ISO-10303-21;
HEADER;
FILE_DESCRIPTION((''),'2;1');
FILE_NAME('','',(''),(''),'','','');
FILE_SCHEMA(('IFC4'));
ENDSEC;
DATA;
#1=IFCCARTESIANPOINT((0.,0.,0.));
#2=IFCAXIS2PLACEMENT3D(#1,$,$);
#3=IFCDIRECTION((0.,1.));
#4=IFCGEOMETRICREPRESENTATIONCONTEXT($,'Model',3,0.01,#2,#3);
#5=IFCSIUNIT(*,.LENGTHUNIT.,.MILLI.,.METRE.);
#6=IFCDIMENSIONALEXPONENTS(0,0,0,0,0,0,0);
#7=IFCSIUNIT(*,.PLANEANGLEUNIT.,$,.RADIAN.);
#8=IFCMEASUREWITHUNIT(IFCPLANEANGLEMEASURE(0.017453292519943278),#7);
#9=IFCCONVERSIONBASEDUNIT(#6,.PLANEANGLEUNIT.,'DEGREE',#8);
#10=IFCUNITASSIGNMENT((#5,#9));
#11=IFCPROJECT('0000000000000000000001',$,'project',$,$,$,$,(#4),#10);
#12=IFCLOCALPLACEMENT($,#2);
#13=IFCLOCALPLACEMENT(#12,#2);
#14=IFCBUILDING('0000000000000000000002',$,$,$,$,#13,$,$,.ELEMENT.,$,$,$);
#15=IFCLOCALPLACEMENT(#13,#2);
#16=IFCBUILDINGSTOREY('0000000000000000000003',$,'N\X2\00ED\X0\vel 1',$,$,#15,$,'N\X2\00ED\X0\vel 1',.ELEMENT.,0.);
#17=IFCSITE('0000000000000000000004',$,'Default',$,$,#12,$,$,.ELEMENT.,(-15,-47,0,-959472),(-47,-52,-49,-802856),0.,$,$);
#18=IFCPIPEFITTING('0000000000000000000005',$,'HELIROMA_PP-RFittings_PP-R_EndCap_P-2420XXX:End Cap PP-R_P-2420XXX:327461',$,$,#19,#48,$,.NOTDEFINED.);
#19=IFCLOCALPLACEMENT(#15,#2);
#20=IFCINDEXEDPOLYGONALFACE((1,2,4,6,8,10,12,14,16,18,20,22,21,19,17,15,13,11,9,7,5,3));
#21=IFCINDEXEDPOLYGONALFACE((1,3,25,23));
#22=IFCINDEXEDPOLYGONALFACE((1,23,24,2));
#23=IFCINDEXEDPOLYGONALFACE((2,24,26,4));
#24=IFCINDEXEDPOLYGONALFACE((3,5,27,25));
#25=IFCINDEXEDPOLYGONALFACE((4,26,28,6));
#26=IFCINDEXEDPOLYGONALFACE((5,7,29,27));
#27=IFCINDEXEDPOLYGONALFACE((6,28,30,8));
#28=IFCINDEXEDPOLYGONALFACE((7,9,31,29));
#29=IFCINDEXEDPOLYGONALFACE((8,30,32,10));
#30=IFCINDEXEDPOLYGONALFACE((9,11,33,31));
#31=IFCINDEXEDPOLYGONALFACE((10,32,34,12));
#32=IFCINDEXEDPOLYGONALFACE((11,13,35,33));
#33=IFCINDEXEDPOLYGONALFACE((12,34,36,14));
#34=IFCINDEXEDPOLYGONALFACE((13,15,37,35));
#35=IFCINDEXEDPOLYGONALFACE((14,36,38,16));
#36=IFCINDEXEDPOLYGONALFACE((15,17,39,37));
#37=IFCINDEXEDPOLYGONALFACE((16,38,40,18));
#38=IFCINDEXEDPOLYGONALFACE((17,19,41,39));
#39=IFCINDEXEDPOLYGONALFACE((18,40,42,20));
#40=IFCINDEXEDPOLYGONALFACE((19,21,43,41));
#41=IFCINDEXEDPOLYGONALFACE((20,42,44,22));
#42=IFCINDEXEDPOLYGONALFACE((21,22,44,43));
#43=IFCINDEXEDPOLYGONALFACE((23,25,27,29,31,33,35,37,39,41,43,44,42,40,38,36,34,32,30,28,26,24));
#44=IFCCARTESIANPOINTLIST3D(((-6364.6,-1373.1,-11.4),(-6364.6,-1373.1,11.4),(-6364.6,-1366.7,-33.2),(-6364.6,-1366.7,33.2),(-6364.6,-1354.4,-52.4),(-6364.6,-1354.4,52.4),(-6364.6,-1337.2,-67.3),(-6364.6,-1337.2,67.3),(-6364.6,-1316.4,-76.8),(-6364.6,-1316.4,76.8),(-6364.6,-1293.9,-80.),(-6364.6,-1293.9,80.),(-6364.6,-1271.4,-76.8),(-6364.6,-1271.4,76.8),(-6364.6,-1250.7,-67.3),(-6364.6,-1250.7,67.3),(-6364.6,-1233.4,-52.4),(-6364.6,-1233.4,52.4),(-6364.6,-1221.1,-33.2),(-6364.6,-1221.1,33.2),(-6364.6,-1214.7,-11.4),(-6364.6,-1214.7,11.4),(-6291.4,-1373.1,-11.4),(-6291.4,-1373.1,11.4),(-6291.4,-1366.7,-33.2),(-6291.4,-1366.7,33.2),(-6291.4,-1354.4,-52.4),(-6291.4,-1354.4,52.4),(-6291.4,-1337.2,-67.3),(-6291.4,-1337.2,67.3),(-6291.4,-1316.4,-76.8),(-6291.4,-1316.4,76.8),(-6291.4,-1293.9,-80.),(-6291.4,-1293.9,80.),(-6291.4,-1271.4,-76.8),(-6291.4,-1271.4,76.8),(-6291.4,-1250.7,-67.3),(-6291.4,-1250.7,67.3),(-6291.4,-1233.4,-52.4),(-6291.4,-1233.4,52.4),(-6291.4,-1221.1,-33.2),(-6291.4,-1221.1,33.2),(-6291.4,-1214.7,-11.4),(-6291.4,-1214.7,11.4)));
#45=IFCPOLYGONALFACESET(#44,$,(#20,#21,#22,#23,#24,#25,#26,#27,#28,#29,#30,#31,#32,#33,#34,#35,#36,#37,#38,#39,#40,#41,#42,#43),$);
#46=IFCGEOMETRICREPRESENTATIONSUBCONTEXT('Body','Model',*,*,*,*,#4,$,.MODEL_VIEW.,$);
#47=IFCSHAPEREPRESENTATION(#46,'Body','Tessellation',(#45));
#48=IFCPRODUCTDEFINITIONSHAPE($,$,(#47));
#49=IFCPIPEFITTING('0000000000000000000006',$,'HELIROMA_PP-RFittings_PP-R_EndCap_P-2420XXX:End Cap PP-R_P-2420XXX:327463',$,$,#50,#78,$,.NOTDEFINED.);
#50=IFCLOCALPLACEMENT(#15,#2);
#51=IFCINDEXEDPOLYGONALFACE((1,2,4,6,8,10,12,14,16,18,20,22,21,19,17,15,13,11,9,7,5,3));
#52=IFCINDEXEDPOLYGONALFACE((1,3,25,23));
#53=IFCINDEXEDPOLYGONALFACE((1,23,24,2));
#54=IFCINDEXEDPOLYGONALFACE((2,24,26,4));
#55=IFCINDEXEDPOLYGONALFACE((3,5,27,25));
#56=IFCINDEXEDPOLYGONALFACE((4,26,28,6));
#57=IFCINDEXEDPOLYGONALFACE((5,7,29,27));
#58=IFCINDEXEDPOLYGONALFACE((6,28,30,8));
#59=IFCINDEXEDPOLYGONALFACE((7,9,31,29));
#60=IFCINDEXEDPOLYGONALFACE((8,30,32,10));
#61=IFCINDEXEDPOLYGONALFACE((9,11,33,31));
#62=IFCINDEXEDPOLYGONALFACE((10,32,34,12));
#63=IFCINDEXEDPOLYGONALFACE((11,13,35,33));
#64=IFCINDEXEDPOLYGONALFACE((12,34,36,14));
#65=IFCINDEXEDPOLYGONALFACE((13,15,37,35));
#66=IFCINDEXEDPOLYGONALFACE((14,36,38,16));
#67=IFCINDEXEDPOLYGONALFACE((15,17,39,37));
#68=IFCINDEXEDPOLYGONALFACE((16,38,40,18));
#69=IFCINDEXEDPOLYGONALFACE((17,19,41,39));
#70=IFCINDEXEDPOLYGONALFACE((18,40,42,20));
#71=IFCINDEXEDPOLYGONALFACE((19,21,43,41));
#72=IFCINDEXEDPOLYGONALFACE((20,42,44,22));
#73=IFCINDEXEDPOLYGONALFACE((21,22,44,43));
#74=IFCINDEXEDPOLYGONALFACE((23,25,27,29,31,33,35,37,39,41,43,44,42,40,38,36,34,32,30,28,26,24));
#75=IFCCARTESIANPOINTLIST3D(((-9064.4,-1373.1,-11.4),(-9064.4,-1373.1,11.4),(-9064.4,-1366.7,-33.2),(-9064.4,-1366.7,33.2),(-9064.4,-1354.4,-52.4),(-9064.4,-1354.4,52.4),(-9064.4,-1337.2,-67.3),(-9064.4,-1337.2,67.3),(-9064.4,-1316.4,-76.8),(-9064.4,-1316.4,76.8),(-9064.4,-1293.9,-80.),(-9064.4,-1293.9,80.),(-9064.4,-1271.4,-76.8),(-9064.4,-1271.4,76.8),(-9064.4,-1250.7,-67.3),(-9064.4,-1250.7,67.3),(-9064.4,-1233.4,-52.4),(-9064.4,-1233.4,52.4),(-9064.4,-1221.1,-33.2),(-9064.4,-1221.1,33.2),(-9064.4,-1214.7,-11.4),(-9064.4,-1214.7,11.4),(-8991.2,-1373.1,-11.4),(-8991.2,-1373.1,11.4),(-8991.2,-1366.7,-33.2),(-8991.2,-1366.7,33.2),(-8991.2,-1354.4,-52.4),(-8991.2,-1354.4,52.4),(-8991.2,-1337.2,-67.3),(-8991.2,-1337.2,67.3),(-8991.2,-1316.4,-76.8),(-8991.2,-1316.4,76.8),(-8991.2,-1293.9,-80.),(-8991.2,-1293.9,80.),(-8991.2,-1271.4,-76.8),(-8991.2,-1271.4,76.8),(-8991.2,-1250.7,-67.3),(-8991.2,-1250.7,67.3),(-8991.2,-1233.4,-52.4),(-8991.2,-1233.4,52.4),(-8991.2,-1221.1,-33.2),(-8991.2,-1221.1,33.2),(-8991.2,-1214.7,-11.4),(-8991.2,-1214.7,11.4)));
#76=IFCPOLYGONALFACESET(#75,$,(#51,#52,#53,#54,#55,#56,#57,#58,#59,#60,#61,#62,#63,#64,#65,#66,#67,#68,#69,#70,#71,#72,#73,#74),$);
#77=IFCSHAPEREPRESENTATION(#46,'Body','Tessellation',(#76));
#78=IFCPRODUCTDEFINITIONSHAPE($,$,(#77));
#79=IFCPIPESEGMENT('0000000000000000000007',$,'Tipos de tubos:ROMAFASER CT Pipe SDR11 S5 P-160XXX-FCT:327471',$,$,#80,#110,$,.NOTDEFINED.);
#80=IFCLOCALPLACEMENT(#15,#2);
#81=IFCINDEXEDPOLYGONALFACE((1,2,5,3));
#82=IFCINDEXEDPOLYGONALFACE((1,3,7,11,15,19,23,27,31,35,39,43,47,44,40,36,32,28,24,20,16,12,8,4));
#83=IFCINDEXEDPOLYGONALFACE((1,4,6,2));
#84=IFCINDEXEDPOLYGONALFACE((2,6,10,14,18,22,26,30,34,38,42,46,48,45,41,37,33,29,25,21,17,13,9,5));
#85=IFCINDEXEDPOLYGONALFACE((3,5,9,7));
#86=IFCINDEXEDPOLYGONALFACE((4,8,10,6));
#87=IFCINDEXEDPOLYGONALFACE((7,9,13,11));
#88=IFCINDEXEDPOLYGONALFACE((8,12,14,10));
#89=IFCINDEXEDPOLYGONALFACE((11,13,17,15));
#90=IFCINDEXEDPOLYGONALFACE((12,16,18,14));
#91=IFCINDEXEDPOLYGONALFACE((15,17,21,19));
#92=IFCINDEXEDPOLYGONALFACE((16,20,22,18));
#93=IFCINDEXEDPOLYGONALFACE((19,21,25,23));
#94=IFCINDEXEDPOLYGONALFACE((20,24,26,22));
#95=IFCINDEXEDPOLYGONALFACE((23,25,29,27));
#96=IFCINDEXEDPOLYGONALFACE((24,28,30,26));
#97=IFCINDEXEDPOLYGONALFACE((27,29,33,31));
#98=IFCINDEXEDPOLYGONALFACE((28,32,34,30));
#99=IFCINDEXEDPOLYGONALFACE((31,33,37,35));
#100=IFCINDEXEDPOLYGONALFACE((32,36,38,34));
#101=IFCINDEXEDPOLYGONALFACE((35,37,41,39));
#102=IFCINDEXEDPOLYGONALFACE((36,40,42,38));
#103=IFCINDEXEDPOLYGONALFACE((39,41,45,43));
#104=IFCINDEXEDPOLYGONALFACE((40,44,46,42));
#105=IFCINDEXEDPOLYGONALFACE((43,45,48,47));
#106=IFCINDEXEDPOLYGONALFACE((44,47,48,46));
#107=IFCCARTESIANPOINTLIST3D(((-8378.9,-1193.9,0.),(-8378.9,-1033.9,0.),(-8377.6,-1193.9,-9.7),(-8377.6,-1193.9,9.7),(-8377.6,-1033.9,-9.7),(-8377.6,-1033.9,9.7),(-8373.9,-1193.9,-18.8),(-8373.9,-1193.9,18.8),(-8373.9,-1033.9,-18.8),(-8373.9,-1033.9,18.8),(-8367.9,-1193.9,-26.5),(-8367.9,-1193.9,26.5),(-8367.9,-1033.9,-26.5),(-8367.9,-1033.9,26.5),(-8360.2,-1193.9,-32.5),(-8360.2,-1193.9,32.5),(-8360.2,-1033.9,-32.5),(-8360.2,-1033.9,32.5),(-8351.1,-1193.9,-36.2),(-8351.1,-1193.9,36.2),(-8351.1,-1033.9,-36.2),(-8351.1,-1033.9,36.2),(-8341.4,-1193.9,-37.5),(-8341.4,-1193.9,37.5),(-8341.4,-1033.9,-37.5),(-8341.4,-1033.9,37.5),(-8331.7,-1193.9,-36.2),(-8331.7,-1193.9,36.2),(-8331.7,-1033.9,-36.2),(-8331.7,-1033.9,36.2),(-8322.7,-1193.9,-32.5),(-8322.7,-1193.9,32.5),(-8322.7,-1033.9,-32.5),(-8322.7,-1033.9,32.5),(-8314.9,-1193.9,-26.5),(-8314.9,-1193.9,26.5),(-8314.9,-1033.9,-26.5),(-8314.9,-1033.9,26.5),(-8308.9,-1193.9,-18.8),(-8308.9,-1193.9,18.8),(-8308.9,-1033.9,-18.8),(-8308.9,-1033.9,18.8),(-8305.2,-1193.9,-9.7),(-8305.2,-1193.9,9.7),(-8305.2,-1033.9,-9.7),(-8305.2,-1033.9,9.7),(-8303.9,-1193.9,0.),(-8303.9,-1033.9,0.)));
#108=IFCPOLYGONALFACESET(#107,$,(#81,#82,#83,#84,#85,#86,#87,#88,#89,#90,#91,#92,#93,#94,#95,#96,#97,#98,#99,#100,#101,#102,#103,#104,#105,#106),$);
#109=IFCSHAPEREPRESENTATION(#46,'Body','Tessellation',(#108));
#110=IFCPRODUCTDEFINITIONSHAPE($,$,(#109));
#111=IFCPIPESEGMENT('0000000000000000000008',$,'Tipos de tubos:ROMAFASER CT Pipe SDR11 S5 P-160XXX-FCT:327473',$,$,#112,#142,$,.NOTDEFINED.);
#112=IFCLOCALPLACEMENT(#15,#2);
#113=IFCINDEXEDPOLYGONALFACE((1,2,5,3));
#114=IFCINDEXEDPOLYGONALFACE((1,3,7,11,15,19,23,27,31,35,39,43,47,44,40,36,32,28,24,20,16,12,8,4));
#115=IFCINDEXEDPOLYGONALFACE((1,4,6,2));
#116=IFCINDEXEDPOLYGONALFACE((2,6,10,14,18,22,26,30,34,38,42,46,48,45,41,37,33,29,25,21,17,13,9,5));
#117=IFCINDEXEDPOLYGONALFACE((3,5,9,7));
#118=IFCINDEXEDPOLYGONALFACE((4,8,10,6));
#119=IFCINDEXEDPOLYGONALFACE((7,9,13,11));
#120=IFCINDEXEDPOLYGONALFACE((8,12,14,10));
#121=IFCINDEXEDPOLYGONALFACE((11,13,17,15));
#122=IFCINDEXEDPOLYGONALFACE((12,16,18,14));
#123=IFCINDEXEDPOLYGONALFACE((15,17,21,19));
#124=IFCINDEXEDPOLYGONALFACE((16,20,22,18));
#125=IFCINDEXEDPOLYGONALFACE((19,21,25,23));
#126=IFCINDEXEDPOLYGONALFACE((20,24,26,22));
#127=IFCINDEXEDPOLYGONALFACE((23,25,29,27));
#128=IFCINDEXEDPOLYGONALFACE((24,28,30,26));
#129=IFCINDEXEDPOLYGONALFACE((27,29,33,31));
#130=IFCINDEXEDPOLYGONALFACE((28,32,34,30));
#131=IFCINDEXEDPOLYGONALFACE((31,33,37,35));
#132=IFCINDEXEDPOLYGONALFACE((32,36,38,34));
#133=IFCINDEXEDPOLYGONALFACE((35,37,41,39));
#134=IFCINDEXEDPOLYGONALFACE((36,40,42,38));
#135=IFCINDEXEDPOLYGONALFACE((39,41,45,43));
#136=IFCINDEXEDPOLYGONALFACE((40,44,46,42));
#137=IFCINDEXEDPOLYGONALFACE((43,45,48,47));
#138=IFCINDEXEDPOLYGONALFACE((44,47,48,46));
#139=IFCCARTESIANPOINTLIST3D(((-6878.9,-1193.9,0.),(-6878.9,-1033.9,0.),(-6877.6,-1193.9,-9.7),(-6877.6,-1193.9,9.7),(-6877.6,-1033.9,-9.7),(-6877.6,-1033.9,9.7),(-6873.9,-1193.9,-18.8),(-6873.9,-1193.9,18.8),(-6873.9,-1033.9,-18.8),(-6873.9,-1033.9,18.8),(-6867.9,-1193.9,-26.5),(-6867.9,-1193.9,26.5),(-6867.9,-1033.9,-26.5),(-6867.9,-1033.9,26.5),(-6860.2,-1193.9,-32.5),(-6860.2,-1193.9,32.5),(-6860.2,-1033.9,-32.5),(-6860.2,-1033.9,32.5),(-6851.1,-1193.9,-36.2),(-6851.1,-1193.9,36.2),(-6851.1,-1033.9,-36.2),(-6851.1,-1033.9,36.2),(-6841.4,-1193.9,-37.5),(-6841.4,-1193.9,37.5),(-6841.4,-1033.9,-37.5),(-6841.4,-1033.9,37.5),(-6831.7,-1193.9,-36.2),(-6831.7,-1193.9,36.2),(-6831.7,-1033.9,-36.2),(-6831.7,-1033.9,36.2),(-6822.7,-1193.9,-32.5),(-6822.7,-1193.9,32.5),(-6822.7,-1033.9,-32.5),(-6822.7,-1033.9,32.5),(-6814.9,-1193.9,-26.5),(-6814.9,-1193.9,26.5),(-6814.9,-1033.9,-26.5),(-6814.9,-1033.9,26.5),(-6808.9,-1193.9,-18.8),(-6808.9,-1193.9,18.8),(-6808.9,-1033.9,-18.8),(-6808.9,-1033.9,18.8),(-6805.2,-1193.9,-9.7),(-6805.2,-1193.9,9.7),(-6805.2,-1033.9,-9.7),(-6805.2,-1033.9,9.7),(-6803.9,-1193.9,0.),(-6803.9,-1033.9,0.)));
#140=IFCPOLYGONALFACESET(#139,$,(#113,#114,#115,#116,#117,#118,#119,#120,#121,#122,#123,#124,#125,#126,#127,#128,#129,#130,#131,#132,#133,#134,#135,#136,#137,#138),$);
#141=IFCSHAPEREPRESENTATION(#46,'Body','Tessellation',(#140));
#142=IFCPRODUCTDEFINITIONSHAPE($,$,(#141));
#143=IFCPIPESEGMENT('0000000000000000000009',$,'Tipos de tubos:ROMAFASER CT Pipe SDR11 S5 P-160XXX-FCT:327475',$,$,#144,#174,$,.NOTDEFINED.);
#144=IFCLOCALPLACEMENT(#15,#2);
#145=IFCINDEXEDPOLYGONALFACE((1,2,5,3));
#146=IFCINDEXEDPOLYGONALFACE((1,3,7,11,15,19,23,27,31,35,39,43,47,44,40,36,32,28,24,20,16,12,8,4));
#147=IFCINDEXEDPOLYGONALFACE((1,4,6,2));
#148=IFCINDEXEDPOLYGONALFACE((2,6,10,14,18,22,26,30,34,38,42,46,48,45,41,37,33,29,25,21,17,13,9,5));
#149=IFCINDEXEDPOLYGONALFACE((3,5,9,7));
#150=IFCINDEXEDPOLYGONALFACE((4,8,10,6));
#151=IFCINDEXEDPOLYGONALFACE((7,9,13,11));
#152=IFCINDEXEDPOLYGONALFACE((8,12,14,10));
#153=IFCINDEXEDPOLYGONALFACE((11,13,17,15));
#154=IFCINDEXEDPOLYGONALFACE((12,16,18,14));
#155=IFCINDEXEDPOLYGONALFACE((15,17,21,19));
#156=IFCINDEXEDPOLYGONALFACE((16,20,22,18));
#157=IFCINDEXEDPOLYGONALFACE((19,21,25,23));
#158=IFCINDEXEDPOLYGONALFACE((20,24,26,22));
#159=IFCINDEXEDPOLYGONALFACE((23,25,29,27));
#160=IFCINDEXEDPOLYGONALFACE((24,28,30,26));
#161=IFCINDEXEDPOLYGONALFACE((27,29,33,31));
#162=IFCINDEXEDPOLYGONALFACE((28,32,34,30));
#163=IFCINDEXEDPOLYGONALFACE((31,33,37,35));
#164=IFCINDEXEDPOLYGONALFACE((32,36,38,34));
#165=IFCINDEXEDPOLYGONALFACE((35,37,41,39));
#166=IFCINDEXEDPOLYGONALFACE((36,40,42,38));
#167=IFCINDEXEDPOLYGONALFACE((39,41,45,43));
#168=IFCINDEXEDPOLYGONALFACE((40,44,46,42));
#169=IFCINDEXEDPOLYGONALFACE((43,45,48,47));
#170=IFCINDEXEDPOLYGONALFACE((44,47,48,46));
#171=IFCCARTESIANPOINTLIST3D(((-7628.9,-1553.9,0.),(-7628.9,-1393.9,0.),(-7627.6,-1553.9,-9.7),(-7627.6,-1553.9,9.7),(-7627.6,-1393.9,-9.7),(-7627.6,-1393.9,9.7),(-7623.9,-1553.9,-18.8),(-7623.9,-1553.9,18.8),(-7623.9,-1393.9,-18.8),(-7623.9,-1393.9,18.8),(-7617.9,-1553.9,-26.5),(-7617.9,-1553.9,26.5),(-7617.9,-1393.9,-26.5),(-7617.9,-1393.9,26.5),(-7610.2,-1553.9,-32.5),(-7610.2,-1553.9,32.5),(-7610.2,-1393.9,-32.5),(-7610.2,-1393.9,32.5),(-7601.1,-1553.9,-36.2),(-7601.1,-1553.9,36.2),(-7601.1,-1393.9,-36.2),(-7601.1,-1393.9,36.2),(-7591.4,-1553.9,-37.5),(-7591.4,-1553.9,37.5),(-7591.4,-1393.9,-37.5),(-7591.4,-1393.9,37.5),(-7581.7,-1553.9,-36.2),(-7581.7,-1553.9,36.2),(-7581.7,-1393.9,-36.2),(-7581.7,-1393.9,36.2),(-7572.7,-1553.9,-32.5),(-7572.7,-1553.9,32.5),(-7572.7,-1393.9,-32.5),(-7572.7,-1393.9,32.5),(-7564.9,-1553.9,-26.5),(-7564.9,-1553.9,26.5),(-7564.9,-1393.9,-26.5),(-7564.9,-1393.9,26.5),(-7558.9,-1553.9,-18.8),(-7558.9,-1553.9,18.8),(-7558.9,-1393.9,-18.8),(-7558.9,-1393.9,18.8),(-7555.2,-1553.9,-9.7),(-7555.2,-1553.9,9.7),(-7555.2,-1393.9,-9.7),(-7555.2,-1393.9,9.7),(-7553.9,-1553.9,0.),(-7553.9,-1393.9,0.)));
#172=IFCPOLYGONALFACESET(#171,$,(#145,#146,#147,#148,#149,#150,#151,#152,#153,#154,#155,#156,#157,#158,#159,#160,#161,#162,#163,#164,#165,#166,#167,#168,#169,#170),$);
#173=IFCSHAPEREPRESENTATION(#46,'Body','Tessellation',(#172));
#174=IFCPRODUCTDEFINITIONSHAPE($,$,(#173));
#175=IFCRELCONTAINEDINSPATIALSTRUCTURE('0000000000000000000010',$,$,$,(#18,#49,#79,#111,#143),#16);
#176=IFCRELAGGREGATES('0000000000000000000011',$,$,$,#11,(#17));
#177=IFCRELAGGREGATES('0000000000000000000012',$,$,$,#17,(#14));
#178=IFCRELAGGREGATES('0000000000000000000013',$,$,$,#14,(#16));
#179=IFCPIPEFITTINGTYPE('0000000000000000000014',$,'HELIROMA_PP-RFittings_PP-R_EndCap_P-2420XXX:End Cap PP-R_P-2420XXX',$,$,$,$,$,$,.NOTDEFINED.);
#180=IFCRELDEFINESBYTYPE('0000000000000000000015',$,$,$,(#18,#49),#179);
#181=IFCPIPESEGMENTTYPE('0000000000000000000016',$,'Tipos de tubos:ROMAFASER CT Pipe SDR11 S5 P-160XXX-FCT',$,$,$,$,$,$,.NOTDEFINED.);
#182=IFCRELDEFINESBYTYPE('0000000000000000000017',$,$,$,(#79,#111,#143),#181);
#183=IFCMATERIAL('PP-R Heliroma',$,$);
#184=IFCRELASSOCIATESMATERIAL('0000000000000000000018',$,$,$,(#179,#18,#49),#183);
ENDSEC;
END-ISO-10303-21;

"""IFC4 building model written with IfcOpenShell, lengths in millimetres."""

from ifc_helpers import new_model, entity, si_unit, converted_unit, direction, frame, origin, place, context, subcontext, project, spatial, arc, indexed_curve, outline, extrude, source, transform, mapped, material, type_object, type_shapes, element, save


model = new_model("IFC4")

# Units and contexts
model_context = context("Model", 3, precision=0.01, world=origin(), true_north=direction((0.0, 1.0)))
body_context = subcontext(model_context, "Body", "Model", "MODEL_VIEW")
ifc_project = project(units=[si_unit("LENGTHUNIT", "METRE", prefix="MILLI"), converted_unit("PLANEANGLEUNIT", "DEGREE", entity("IfcPlaneAngleMeasure", 0.017453292519943278), si_unit("PLANEANGLEUNIT", "RADIAN"), dimensions=[0, 0, 0, 0, 0, 0, 0])], contexts=[model_context])

# Site, building, storey
site_placement = place(None, origin())
site = spatial("IfcSite", under=ifc_project, at=site_placement, Name="Default", CompositionType="ELEMENT", RefLatitude=(-15, -47, 0, -959472), RefLongitude=(-47, -52, -49, -802856), RefElevation=0.0)
building_placement = place(site_placement, origin())
building = spatial("IfcBuilding", under=site, at=building_placement, CompositionType="ELEMENT")
storey_placement = place(building_placement, origin())
storey = spatial("IfcBuildingStorey", under=building, at=storey_placement, Name="Nível 1", LongName="Nível 1", CompositionType="ELEMENT", Elevation=0.0)

# Pipe fittings
ifc_material_1 = material(Name="PP-R Heliroma")
pipe_fitting_type_1 = type_object("IfcPipeFittingType", Name="HELIROMA_PP-RFittings_PP-R_EndCap_P-2420XXX:End Cap PP-R_P-2420XXX", PredefinedType="NOTDEFINED", material=ifc_material_1)
shared_shape_1 = source(origin(), body_context, "Body", "SweptSolid", [
    extrude(outline(indexed_curve([(-80.0, 0.0), (0.0, -80.0), (80.0, 0.0), (0.0, 80.0)], segments=[arc(1, 2, 3), arc(3, 4, 1)], self_intersect=False)), frame((0.0, 0.0, 0.0), z_axis=(1.0, 0.0, 0.0), x_axis=(0.0, 1.0, 0.0)), (0.0, 0.0, 1.0), 73.2),
])
type_shapes(pipe_fitting_type_1, [shared_shape_1])
for number, where, z_axis, x_axis, name in (
    (1, (-6364.6, -1293.9, 0.0), (0.0, -1.0, 0.0), (1.0, 0.0, 0.0), "HELIROMA_PP-RFittings_PP-R_EndCap_P-2420XXX:End Cap PP-R_P-2420XXX:327461"),
    (2, (-8991.2, -1293.9, 0.0), (0.0, 1.0, 0.0), (-1.0, 0.0, 0.0), "HELIROMA_PP-RFittings_PP-R_EndCap_P-2420XXX:End Cap PP-R_P-2420XXX:327463"),
):
    element("IfcPipeFitting", number, at=place(storey_placement, frame(where, z_axis=z_axis, x_axis=x_axis)), inside=storey, type_object=pipe_fitting_type_1, material=ifc_material_1, Name=name, PredefinedType="NOTDEFINED", context=body_context, shape_type="MappedRepresentation", body=[
        mapped(shared_shape_1, transform((0.0, 0.0, 0.0), scale=1.0)),
    ])

# Pipe segments
pipe_segment_type = type_object("IfcPipeSegmentType", Name="Tipos de tubos:ROMAFASER CT Pipe SDR11 S5 P-160XXX-FCT", PredefinedType="NOTDEFINED")
pipe_segment_1_placement = place(storey_placement, origin())
element("IfcPipeSegment", 3, at=pipe_segment_1_placement, inside=storey, type_object=pipe_segment_type, Name="Tipos de tubos:ROMAFASER CT Pipe SDR11 S5 P-160XXX-FCT:327471", PredefinedType="NOTDEFINED", context=body_context, shape_type="SweptSolid", body=[
    extrude(outline(indexed_curve([(37.5, 0.0), (26.5, 26.5), (0.0, 37.5), (-26.5, 26.5), (-37.5, 0.0), (-26.5, -26.5), (0.0, -37.5), (26.5, -26.5)], segments=[arc(1, 2, 3), arc(3, 4, 5), arc(5, 6, 7), arc(7, 8, 1)], self_intersect=False)), frame((-8341.4, -1193.9, 0.0), z_axis=(0.0, 1.0, 0.0), x_axis=(-1.0, 0.0, 0.0)), (0.0, 0.0, 1.0), 160.0),
])
pipe_segment_2_placement = place(storey_placement, origin())
element("IfcPipeSegment", 4, at=pipe_segment_2_placement, inside=storey, type_object=pipe_segment_type, Name="Tipos de tubos:ROMAFASER CT Pipe SDR11 S5 P-160XXX-FCT:327473", PredefinedType="NOTDEFINED", context=body_context, shape_type="SweptSolid", body=[
    extrude(outline(indexed_curve([(37.5, 0.0), (26.5, 26.5), (0.0, 37.5), (-26.5, 26.5), (-37.5, 0.0), (-26.5, -26.5), (0.0, -37.5), (26.5, -26.5)], segments=[arc(1, 2, 3), arc(3, 4, 5), arc(5, 6, 7), arc(7, 8, 1)], self_intersect=False)), frame((-6841.4, -1193.9, 0.0), z_axis=(0.0, 1.0, 0.0), x_axis=(-1.0, 0.0, 0.0)), (0.0, 0.0, 1.0), 160.0),
])
pipe_segment_3_placement = place(storey_placement, origin())
element("IfcPipeSegment", 5, at=pipe_segment_3_placement, inside=storey, type_object=pipe_segment_type, Name="Tipos de tubos:ROMAFASER CT Pipe SDR11 S5 P-160XXX-FCT:327475", PredefinedType="NOTDEFINED", context=body_context, shape_type="SweptSolid", body=[
    extrude(outline(indexed_curve([(37.5, 0.0), (26.5, 26.5), (0.0, 37.5), (-26.5, 26.5), (-37.5, 0.0), (-26.5, -26.5), (0.0, -37.5), (26.5, -26.5)], segments=[arc(1, 2, 3), arc(3, 4, 5), arc(5, 6, 7), arc(7, 8, 1)], self_intersect=False)), frame((-7591.4, -1553.9, 0.0), z_axis=(0.0, 1.0, 0.0), x_axis=(1.0, 0.0, 0.0)), (0.0, 0.0, 1.0), 160.0),
])

save(model, "model.ifc")
